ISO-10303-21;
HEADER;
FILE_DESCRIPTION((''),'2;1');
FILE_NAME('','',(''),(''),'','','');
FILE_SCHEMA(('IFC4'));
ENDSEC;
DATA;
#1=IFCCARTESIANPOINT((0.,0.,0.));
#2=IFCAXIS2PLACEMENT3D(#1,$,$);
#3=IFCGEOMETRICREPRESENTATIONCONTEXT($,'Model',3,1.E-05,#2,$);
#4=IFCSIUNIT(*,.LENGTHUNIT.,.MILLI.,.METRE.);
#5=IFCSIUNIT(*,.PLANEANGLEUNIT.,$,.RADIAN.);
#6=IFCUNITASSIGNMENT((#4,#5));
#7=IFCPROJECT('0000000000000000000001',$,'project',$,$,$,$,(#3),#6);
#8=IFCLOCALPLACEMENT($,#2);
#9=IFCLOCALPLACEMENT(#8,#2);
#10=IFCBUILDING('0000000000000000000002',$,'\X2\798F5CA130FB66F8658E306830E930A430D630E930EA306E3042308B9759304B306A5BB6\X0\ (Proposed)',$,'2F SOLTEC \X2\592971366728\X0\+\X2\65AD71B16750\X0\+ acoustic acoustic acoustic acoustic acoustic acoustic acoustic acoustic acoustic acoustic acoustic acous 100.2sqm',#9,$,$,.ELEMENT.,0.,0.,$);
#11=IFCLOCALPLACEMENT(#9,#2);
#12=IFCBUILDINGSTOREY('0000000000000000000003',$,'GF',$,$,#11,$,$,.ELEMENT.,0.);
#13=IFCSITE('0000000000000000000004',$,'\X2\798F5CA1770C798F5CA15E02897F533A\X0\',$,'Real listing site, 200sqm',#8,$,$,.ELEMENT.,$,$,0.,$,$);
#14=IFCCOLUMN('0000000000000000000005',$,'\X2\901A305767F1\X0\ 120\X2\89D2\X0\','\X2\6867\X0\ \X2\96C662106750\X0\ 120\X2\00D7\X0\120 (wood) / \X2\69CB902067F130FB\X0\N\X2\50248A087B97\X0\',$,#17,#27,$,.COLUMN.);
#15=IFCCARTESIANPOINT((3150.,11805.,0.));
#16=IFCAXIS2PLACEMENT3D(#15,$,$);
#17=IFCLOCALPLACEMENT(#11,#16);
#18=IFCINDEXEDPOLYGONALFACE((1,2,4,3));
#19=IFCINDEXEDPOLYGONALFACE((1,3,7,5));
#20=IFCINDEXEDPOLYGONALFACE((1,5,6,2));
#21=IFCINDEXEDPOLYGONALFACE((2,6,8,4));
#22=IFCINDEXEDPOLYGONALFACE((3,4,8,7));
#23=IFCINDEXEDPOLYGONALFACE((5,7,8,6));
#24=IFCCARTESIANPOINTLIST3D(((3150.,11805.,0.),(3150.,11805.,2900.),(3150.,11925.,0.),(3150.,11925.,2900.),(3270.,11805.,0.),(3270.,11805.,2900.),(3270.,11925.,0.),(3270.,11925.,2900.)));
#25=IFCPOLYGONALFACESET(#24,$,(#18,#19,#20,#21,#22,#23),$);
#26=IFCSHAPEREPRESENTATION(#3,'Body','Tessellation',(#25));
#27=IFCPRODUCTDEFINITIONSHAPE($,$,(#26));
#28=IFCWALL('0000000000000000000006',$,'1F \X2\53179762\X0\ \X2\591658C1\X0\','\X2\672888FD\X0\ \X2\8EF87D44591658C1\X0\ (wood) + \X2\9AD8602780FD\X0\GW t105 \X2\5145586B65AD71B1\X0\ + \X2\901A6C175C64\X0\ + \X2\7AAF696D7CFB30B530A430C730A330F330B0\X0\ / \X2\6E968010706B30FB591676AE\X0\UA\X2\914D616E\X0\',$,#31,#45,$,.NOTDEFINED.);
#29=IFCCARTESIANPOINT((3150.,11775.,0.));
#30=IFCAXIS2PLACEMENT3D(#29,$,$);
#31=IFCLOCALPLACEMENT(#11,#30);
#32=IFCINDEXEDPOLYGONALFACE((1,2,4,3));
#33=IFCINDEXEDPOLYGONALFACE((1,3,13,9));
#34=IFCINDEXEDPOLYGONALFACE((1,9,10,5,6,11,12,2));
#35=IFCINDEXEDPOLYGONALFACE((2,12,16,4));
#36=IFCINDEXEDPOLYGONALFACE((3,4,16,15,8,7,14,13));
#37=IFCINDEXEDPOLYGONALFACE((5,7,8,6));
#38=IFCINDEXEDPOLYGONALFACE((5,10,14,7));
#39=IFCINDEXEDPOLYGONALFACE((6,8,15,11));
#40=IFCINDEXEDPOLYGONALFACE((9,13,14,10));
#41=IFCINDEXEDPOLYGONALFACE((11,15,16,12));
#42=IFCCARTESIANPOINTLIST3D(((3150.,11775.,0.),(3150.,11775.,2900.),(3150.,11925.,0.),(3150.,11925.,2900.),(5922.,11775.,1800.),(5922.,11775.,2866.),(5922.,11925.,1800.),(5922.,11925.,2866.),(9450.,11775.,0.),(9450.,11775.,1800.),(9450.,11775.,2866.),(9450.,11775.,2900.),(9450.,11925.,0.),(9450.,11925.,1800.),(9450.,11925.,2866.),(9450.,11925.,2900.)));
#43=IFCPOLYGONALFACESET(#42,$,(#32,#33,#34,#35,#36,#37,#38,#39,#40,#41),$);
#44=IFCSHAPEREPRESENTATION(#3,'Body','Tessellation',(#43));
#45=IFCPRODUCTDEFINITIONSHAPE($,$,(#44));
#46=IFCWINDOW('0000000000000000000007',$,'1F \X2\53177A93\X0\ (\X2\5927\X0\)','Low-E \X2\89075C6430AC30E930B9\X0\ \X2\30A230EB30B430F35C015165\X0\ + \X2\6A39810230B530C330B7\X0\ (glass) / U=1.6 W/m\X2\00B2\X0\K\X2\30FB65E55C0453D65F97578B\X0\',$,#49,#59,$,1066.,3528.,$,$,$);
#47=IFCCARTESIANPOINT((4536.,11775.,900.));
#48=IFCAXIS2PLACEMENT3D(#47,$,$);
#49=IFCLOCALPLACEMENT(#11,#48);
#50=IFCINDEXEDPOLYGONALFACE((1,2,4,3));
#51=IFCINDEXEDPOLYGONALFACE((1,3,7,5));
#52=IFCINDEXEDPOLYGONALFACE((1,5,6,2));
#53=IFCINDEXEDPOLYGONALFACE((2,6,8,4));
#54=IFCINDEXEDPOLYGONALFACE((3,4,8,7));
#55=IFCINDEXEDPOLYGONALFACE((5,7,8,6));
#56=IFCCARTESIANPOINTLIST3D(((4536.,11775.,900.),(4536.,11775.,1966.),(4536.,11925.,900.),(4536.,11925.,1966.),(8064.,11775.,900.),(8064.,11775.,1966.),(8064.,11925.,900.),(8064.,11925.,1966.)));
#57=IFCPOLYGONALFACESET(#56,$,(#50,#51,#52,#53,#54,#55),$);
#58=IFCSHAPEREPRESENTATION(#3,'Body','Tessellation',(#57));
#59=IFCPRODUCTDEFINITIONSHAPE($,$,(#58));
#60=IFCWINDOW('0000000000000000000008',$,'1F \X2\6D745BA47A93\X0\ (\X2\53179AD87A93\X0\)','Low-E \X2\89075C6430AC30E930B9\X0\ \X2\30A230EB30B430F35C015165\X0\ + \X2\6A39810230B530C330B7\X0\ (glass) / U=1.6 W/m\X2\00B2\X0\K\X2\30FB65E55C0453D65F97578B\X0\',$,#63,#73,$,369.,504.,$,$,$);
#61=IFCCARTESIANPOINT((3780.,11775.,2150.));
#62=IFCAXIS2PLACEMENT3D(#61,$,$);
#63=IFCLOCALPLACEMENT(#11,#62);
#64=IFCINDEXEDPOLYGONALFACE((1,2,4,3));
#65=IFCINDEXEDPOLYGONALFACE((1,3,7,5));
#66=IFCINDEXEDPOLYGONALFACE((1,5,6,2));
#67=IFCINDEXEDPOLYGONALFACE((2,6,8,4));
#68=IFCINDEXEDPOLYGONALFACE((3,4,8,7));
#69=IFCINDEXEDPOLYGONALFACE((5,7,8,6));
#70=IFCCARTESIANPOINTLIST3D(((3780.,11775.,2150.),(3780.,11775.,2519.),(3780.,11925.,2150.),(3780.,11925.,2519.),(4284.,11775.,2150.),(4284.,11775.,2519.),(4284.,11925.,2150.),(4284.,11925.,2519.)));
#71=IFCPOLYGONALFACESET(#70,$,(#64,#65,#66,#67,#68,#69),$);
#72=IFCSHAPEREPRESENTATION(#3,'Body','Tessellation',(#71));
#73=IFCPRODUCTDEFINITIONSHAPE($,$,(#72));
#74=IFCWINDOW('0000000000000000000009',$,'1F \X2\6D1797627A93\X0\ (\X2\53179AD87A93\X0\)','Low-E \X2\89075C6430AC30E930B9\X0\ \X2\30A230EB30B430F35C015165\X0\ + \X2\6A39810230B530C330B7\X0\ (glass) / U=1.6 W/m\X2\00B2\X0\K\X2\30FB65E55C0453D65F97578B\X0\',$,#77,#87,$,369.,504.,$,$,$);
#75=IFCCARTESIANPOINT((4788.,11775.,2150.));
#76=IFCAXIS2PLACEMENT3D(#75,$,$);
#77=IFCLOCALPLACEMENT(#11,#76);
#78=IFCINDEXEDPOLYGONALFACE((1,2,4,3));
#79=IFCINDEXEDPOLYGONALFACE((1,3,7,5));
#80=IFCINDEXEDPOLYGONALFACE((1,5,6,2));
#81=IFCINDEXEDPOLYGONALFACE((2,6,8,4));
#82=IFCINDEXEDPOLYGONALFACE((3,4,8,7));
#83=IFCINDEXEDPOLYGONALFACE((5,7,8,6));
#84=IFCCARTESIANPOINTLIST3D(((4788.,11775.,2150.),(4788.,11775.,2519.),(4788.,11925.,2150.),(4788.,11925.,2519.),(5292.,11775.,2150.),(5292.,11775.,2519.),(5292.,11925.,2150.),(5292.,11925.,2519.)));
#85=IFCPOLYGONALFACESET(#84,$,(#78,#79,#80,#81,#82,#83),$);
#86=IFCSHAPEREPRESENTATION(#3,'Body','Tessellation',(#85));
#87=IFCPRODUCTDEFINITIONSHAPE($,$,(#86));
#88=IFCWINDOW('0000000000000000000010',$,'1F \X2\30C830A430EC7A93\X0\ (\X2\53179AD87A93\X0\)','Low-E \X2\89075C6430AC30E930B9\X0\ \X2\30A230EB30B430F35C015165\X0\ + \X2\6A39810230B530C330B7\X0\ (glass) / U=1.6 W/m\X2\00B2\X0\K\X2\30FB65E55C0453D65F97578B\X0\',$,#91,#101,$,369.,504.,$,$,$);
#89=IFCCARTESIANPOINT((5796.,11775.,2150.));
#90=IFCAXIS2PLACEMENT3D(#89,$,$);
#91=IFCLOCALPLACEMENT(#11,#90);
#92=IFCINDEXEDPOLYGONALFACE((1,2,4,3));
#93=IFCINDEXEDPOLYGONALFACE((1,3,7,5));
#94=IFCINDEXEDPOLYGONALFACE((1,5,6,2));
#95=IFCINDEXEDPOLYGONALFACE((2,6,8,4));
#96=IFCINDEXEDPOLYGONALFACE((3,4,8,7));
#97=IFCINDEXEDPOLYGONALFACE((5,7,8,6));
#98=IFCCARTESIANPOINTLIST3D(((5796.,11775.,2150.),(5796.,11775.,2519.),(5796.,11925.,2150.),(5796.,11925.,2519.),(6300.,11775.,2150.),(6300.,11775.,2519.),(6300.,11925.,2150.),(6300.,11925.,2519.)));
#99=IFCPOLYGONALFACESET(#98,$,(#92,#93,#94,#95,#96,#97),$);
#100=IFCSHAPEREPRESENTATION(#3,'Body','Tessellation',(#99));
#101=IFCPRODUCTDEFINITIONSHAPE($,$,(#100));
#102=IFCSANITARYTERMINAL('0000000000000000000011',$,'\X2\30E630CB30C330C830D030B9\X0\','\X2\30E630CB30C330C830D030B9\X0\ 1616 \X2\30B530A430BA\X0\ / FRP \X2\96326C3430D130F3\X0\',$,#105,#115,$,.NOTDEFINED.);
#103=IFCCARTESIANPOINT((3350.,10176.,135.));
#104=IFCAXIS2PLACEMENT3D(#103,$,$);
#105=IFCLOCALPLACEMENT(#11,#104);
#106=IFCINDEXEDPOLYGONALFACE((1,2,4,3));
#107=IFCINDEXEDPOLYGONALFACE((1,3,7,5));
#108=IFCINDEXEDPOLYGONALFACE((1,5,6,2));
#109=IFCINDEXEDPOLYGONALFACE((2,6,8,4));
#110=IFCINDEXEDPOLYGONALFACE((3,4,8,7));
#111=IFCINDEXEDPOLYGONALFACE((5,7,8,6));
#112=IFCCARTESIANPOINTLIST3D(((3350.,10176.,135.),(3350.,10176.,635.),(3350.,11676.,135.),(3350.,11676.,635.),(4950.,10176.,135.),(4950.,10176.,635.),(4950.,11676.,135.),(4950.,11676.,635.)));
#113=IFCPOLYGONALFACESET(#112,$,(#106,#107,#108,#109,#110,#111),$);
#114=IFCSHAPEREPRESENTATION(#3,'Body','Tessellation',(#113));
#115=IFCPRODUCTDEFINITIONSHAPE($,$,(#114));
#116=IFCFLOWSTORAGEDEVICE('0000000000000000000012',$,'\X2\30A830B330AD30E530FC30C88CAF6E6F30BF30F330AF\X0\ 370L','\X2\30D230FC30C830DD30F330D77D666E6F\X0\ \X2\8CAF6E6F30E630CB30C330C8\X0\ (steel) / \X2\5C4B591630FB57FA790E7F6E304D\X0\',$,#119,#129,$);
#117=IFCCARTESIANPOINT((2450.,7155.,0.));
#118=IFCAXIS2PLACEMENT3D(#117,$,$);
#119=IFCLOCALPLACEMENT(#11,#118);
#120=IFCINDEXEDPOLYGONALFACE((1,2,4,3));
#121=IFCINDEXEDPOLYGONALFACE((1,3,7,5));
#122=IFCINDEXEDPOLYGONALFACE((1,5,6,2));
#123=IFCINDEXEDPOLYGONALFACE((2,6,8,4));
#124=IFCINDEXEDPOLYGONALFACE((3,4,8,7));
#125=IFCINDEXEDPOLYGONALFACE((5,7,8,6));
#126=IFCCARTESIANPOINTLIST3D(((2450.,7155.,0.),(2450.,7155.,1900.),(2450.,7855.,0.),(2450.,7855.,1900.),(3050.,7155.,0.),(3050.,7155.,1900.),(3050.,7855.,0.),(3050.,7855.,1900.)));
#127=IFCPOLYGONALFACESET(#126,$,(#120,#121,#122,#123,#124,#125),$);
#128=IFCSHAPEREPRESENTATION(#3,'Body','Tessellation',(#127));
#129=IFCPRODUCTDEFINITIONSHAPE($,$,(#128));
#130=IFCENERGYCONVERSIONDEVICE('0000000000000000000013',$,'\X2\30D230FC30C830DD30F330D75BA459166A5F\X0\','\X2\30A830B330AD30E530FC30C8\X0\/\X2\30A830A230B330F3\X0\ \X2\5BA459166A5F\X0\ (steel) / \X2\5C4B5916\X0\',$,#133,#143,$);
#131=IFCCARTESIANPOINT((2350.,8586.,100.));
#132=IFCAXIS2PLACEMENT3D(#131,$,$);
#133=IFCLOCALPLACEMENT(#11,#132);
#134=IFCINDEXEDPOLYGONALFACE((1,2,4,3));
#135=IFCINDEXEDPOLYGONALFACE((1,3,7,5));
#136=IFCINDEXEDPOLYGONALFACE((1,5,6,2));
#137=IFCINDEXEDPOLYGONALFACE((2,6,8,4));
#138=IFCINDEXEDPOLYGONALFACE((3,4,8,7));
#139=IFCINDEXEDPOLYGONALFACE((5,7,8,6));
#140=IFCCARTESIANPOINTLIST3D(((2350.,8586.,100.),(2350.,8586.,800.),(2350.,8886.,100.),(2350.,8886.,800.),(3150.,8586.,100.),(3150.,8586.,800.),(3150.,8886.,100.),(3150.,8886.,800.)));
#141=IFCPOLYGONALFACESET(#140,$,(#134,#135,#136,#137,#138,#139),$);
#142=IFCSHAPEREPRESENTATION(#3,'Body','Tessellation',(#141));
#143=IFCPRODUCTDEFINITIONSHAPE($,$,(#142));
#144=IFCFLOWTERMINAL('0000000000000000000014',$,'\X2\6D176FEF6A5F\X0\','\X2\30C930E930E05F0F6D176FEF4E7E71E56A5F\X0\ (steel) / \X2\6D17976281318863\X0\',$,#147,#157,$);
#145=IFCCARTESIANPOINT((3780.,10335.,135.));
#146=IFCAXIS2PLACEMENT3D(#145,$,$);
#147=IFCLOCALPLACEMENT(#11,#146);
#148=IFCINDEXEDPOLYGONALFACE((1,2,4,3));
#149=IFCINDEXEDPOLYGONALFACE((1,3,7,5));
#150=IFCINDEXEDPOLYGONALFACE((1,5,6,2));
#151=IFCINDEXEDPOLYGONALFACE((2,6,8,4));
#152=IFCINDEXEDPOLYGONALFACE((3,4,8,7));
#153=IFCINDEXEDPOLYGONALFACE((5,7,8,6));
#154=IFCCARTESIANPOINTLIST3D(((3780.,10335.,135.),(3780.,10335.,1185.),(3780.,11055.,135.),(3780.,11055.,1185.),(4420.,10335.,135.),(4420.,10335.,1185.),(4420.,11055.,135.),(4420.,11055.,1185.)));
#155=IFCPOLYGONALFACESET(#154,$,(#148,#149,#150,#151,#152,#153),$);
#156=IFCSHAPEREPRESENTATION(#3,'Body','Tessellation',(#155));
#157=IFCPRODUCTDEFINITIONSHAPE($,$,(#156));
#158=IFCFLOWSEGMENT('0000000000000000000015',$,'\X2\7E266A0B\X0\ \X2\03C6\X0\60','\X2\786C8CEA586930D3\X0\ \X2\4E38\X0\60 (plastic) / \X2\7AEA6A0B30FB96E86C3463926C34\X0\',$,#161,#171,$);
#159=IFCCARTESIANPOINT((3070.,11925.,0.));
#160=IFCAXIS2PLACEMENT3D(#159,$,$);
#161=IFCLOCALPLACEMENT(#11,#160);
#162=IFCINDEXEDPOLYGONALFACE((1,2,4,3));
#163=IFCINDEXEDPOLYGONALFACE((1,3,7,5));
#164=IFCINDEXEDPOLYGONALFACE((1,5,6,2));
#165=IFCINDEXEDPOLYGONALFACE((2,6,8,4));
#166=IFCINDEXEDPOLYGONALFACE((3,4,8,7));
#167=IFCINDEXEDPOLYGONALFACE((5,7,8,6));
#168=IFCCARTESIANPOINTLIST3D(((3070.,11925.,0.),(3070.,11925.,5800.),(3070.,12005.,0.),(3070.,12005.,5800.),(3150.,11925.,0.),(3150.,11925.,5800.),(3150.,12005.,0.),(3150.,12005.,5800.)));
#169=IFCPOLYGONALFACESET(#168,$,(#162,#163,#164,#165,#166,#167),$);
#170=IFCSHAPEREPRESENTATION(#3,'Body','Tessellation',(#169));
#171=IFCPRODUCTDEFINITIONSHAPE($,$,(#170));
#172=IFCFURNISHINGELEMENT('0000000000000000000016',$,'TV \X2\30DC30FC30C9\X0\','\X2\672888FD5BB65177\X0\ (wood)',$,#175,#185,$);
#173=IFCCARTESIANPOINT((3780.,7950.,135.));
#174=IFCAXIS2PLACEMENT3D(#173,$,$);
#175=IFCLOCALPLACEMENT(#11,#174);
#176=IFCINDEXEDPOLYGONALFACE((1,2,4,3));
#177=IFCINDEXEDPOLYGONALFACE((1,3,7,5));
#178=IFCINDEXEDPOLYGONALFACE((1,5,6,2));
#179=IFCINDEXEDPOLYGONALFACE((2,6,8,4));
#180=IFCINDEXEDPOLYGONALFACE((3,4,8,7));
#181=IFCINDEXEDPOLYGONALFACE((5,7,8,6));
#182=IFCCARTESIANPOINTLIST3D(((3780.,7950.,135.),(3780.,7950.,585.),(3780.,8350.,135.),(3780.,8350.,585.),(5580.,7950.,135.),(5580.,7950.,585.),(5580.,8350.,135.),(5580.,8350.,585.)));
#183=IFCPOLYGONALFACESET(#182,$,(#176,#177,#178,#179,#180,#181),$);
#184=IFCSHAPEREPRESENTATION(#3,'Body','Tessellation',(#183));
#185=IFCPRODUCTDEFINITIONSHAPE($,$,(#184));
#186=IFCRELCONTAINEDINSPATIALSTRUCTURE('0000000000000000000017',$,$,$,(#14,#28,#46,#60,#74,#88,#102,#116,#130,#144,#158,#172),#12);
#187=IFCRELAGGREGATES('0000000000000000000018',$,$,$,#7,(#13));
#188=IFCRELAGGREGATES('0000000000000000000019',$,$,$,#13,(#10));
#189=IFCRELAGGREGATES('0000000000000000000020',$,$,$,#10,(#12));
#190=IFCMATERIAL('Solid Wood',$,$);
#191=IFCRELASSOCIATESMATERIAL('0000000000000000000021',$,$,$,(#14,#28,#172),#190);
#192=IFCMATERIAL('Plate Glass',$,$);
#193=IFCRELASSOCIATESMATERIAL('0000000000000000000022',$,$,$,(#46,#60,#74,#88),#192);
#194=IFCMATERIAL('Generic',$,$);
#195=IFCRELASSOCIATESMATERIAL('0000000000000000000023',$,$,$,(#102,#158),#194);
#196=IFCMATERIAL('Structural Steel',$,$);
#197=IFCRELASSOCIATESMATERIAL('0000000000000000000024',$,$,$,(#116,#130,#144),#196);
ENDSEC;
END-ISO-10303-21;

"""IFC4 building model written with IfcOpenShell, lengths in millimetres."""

from ifc_helpers import new_model, si_unit, frame, frame_2d, origin, place, context, project, spatial, rectangle, extrude, material, element, fill, save


model = new_model("IFC4")

# Units and contexts
model_context = context("Model", 3, precision=1e-05, world=origin())
ifc_project = project(units=[si_unit("LENGTHUNIT", "METRE", prefix="MILLI"), si_unit("PLANEANGLEUNIT", "RADIAN")], contexts=[model_context])

# Site, building, storey
site_placement = place(None, origin())
site = spatial("IfcSite", under=ifc_project, at=site_placement, Name="福岡県福岡市西区", ObjectType="Real listing site, 200sqm", CompositionType="ELEMENT", RefElevation=0.0)
building_placement = place(site_placement, origin())
building = spatial("IfcBuilding", under=site, at=building_placement, Name="福岡・書斎とライブラリのある静かな家 (Proposed)", ObjectType="2F SOLTEC 天然木+断熱材+ acoustic acoustic acoustic acoustic acoustic acoustic acoustic acoustic acoustic acoustic acoustic acous 100.2sqm", CompositionType="ELEMENT", ElevationOfRefHeight=0.0, ElevationOfTerrain=0.0)
storey_placement = place(building_placement, origin())
storey = spatial("IfcBuildingStorey", under=building, at=storey_placement, Name="GF", CompositionType="ELEMENT", Elevation=0.0)

# Column
ifc_material_1 = material(Name="Solid Wood")
column_1_placement = place(storey_placement, frame((3150.0, 11805.0, 0.0)))
element("IfcColumn", 1, at=column_1_placement, inside=storey, material=ifc_material_1, Name="通し柱 120角", Description="桧 集成材 120×120 (wood) / 構造柱・N値計算", PredefinedType="COLUMN", context=model_context, shape_type="SweptSolid", body=[
    extrude(rectangle(XDim=120.0, YDim=120.0, at=frame_2d((60.0, 60.0))), frame((3150.0, 11805.0, 0.0)), (0.0, 0.0, 1.0), 2900.0),
])

# Wall, openings, windows
wall_1_placement = place(storey_placement, frame((3150.0, 11775.0, 0.0)))
wall_1 = element("IfcWall", 2, at=wall_1_placement, inside=storey, material=ifc_material_1, Name="1F 北面 外壁", Description="木製 軸組外壁 (wood) + 高性能GW t105 充填断熱 + 通気層 + 窯業系サイディング / 準耐火・外皮UA配慮", PredefinedType="NOTDEFINED", context=model_context, shape_type="SweptSolid", body=[
    extrude(rectangle(XDim=6300.0, YDim=150.0, at=frame_2d((3150.0, 75.0))), frame((3150.0, 11775.0, 0.0)), (0.0, 0.0, 1.0), 2900.0),
])
opening_1_placement = place(storey_placement, frame((4536.0, 11775.0, 900.0)))
opening_1 = element("IfcOpeningElement", 3, at=opening_1_placement, cuts=wall_1, PredefinedType="NOTDEFINED", context=model_context, shape_type="SweptSolid", body=[
    extrude(rectangle(XDim=3528.0, YDim=150.0, at=frame_2d((1764.0, 75.0))), frame((4536.0, 11775.0, 900.0)), (0.0, 0.0, 1.0), 1066.0),
])
opening_2_placement = place(storey_placement, frame((3780.0, 11775.0, 2150.0)))
opening_2 = element("IfcOpeningElement", 4, at=opening_2_placement, cuts=wall_1, PredefinedType="NOTDEFINED", context=model_context, shape_type="SweptSolid", body=[
    extrude(rectangle(XDim=504.0, YDim=150.0, at=frame_2d((252.0, 75.0))), frame((3780.0, 11775.0, 2150.0)), (0.0, 0.0, 1.0), 369.0),
])
opening_3_placement = place(storey_placement, frame((4788.0, 11775.0, 2150.0)))
opening_3 = element("IfcOpeningElement", 5, at=opening_3_placement, cuts=wall_1, PredefinedType="NOTDEFINED", context=model_context, shape_type="SweptSolid", body=[
    extrude(rectangle(XDim=504.0, YDim=150.0, at=frame_2d((252.0, 75.0))), frame((4788.0, 11775.0, 2150.0)), (0.0, 0.0, 1.0), 369.0),
])
opening_4_placement = place(storey_placement, frame((5796.0, 11775.0, 2150.0)))
opening_4 = element("IfcOpeningElement", 6, at=opening_4_placement, cuts=wall_1, PredefinedType="NOTDEFINED", context=model_context, shape_type="SweptSolid", body=[
    extrude(rectangle(XDim=504.0, YDim=150.0, at=frame_2d((252.0, 75.0))), frame((5796.0, 11775.0, 2150.0)), (0.0, 0.0, 1.0), 369.0),
])
ifc_material_2 = material(Name="Plate Glass")
window_1_placement = place(storey_placement, frame((4536.0, 11775.0, 900.0)))
window_1 = element("IfcWindow", 7, at=window_1_placement, inside=storey, material=ifc_material_2, Name="1F 北窓 (大)", Description="Low-E 複層ガラス アルゴン封入 + 樹脂サッシ (glass) / U=1.6 W/m²K・日射取得型", OverallHeight=1066.0, OverallWidth=3528.0, context=model_context, shape_type="SweptSolid", body=[
    extrude(rectangle(XDim=3528.0, YDim=150.0, at=frame_2d((1764.0, 75.0))), frame((4536.0, 11775.0, 900.0)), (0.0, 0.0, 1.0), 1066.0),
])
fill(opening_1, window_1)
window_2_placement = place(storey_placement, frame((3780.0, 11775.0, 2150.0)))
window_2 = element("IfcWindow", 8, at=window_2_placement, inside=storey, material=ifc_material_2, Name="1F 浴室窓 (北高窓)", Description="Low-E 複層ガラス アルゴン封入 + 樹脂サッシ (glass) / U=1.6 W/m²K・日射取得型", OverallHeight=369.0, OverallWidth=504.0, context=model_context, shape_type="SweptSolid", body=[
    extrude(rectangle(XDim=504.0, YDim=150.0, at=frame_2d((252.0, 75.0))), frame((3780.0, 11775.0, 2150.0)), (0.0, 0.0, 1.0), 369.0),
])
fill(opening_2, window_2)
window_3_placement = place(storey_placement, frame((4788.0, 11775.0, 2150.0)))
window_3 = element("IfcWindow", 9, at=window_3_placement, inside=storey, material=ifc_material_2, Name="1F 洗面窓 (北高窓)", Description="Low-E 複層ガラス アルゴン封入 + 樹脂サッシ (glass) / U=1.6 W/m²K・日射取得型", OverallHeight=369.0, OverallWidth=504.0, context=model_context, shape_type="SweptSolid", body=[
    extrude(rectangle(XDim=504.0, YDim=150.0, at=frame_2d((252.0, 75.0))), frame((4788.0, 11775.0, 2150.0)), (0.0, 0.0, 1.0), 369.0),
])
fill(opening_3, window_3)
window_4_placement = place(storey_placement, frame((5796.0, 11775.0, 2150.0)))
window_4 = element("IfcWindow", 10, at=window_4_placement, inside=storey, material=ifc_material_2, Name="1F トイレ窓 (北高窓)", Description="Low-E 複層ガラス アルゴン封入 + 樹脂サッシ (glass) / U=1.6 W/m²K・日射取得型", OverallHeight=369.0, OverallWidth=504.0, context=model_context, shape_type="SweptSolid", body=[
    extrude(rectangle(XDim=504.0, YDim=150.0, at=frame_2d((252.0, 75.0))), frame((5796.0, 11775.0, 2150.0)), (0.0, 0.0, 1.0), 369.0),
])
fill(opening_4, window_4)

# Sanitary terminal
ifc_material_3 = material(Name="Generic")
sanitary_terminal_placement = place(storey_placement, frame((3350.0, 10176.0, 135.0)))
element("IfcSanitaryTerminal", 11, at=sanitary_terminal_placement, inside=storey, material=ifc_material_3, Name="ユニットバス", Description="ユニットバス 1616 サイズ / FRP 防水パン", PredefinedType="NOTDEFINED", context=model_context, shape_type="SweptSolid", body=[
    extrude(rectangle(XDim=1600.0, YDim=1500.0, at=frame_2d((800.0, 750.0))), frame((3350.0, 10176.0, 135.0)), (0.0, 0.0, 1.0), 500.0),
])

# Flow storage device
ifc_material_4 = material(Name="Structural Steel")
flow_storage_device_placement = place(storey_placement, frame((2450.0, 7155.0, 0.0)))
element("IfcFlowStorageDevice", 12, at=flow_storage_device_placement, inside=storey, material=ifc_material_4, Name="エコキュート貯湯タンク 370L", Description="ヒートポンプ給湯 貯湯ユニット (steel) / 屋外・基礎置き", context=model_context, shape_type="SweptSolid", body=[
    extrude(rectangle(XDim=600.0, YDim=700.0, at=frame_2d((300.0, 350.0))), frame((2450.0, 7155.0, 0.0)), (0.0, 0.0, 1.0), 1900.0),
])

# Energy conversion device
energy_conversion_device_placement = place(storey_placement, frame((2350.0, 8586.0, 100.0)))
element("IfcEnergyConversionDevice", 13, at=energy_conversion_device_placement, inside=storey, material=ifc_material_4, Name="ヒートポンプ室外機", Description="エコキュート/エアコン 室外機 (steel) / 屋外", context=model_context, shape_type="SweptSolid", body=[
    extrude(rectangle(XDim=800.0, YDim=300.0, at=frame_2d((400.0, 150.0))), frame((2350.0, 8586.0, 100.0)), (0.0, 0.0, 1.0), 700.0),
])

# Flow terminal
flow_terminal_placement = place(storey_placement, frame((3780.0, 10335.0, 135.0)))
element("IfcFlowTerminal", 14, at=flow_terminal_placement, inside=storey, material=ifc_material_4, Name="洗濯機", Description="ドラム式洗濯乾燥機 (steel) / 洗面脱衣", context=model_context, shape_type="SweptSolid", body=[
    extrude(rectangle(XDim=640.0, YDim=720.0, at=frame_2d((320.0, 360.0))), frame((3780.0, 10335.0, 135.0)), (0.0, 0.0, 1.0), 1050.0),
])

# Flow segment
flow_segment_placement = place(storey_placement, frame((3070.0, 11925.0, 0.0)))
element("IfcFlowSegment", 15, at=flow_segment_placement, inside=storey, material=ifc_material_3, Name="縦樋 φ60", Description="硬質塩ビ 丸60 (plastic) / 竪樋・雨水排水", context=model_context, shape_type="SweptSolid", body=[
    extrude(rectangle(XDim=80.0, YDim=80.0, at=frame_2d((40.0, 40.0))), frame((3070.0, 11925.0, 0.0)), (0.0, 0.0, 1.0), 5800.0),
])

# Furnishing element
furnishing_placement = place(storey_placement, frame((3780.0, 7950.0, 135.0)))
element("IfcFurnishingElement", 16, at=furnishing_placement, inside=storey, material=ifc_material_1, Name="TV ボード", Description="木製家具 (wood)", context=model_context, shape_type="SweptSolid", body=[
    extrude(rectangle(XDim=1800.0, YDim=400.0, at=frame_2d((900.0, 200.0))), frame((3780.0, 7950.0, 135.0)), (0.0, 0.0, 1.0), 450.0),
])

save(model, "model.ifc")
